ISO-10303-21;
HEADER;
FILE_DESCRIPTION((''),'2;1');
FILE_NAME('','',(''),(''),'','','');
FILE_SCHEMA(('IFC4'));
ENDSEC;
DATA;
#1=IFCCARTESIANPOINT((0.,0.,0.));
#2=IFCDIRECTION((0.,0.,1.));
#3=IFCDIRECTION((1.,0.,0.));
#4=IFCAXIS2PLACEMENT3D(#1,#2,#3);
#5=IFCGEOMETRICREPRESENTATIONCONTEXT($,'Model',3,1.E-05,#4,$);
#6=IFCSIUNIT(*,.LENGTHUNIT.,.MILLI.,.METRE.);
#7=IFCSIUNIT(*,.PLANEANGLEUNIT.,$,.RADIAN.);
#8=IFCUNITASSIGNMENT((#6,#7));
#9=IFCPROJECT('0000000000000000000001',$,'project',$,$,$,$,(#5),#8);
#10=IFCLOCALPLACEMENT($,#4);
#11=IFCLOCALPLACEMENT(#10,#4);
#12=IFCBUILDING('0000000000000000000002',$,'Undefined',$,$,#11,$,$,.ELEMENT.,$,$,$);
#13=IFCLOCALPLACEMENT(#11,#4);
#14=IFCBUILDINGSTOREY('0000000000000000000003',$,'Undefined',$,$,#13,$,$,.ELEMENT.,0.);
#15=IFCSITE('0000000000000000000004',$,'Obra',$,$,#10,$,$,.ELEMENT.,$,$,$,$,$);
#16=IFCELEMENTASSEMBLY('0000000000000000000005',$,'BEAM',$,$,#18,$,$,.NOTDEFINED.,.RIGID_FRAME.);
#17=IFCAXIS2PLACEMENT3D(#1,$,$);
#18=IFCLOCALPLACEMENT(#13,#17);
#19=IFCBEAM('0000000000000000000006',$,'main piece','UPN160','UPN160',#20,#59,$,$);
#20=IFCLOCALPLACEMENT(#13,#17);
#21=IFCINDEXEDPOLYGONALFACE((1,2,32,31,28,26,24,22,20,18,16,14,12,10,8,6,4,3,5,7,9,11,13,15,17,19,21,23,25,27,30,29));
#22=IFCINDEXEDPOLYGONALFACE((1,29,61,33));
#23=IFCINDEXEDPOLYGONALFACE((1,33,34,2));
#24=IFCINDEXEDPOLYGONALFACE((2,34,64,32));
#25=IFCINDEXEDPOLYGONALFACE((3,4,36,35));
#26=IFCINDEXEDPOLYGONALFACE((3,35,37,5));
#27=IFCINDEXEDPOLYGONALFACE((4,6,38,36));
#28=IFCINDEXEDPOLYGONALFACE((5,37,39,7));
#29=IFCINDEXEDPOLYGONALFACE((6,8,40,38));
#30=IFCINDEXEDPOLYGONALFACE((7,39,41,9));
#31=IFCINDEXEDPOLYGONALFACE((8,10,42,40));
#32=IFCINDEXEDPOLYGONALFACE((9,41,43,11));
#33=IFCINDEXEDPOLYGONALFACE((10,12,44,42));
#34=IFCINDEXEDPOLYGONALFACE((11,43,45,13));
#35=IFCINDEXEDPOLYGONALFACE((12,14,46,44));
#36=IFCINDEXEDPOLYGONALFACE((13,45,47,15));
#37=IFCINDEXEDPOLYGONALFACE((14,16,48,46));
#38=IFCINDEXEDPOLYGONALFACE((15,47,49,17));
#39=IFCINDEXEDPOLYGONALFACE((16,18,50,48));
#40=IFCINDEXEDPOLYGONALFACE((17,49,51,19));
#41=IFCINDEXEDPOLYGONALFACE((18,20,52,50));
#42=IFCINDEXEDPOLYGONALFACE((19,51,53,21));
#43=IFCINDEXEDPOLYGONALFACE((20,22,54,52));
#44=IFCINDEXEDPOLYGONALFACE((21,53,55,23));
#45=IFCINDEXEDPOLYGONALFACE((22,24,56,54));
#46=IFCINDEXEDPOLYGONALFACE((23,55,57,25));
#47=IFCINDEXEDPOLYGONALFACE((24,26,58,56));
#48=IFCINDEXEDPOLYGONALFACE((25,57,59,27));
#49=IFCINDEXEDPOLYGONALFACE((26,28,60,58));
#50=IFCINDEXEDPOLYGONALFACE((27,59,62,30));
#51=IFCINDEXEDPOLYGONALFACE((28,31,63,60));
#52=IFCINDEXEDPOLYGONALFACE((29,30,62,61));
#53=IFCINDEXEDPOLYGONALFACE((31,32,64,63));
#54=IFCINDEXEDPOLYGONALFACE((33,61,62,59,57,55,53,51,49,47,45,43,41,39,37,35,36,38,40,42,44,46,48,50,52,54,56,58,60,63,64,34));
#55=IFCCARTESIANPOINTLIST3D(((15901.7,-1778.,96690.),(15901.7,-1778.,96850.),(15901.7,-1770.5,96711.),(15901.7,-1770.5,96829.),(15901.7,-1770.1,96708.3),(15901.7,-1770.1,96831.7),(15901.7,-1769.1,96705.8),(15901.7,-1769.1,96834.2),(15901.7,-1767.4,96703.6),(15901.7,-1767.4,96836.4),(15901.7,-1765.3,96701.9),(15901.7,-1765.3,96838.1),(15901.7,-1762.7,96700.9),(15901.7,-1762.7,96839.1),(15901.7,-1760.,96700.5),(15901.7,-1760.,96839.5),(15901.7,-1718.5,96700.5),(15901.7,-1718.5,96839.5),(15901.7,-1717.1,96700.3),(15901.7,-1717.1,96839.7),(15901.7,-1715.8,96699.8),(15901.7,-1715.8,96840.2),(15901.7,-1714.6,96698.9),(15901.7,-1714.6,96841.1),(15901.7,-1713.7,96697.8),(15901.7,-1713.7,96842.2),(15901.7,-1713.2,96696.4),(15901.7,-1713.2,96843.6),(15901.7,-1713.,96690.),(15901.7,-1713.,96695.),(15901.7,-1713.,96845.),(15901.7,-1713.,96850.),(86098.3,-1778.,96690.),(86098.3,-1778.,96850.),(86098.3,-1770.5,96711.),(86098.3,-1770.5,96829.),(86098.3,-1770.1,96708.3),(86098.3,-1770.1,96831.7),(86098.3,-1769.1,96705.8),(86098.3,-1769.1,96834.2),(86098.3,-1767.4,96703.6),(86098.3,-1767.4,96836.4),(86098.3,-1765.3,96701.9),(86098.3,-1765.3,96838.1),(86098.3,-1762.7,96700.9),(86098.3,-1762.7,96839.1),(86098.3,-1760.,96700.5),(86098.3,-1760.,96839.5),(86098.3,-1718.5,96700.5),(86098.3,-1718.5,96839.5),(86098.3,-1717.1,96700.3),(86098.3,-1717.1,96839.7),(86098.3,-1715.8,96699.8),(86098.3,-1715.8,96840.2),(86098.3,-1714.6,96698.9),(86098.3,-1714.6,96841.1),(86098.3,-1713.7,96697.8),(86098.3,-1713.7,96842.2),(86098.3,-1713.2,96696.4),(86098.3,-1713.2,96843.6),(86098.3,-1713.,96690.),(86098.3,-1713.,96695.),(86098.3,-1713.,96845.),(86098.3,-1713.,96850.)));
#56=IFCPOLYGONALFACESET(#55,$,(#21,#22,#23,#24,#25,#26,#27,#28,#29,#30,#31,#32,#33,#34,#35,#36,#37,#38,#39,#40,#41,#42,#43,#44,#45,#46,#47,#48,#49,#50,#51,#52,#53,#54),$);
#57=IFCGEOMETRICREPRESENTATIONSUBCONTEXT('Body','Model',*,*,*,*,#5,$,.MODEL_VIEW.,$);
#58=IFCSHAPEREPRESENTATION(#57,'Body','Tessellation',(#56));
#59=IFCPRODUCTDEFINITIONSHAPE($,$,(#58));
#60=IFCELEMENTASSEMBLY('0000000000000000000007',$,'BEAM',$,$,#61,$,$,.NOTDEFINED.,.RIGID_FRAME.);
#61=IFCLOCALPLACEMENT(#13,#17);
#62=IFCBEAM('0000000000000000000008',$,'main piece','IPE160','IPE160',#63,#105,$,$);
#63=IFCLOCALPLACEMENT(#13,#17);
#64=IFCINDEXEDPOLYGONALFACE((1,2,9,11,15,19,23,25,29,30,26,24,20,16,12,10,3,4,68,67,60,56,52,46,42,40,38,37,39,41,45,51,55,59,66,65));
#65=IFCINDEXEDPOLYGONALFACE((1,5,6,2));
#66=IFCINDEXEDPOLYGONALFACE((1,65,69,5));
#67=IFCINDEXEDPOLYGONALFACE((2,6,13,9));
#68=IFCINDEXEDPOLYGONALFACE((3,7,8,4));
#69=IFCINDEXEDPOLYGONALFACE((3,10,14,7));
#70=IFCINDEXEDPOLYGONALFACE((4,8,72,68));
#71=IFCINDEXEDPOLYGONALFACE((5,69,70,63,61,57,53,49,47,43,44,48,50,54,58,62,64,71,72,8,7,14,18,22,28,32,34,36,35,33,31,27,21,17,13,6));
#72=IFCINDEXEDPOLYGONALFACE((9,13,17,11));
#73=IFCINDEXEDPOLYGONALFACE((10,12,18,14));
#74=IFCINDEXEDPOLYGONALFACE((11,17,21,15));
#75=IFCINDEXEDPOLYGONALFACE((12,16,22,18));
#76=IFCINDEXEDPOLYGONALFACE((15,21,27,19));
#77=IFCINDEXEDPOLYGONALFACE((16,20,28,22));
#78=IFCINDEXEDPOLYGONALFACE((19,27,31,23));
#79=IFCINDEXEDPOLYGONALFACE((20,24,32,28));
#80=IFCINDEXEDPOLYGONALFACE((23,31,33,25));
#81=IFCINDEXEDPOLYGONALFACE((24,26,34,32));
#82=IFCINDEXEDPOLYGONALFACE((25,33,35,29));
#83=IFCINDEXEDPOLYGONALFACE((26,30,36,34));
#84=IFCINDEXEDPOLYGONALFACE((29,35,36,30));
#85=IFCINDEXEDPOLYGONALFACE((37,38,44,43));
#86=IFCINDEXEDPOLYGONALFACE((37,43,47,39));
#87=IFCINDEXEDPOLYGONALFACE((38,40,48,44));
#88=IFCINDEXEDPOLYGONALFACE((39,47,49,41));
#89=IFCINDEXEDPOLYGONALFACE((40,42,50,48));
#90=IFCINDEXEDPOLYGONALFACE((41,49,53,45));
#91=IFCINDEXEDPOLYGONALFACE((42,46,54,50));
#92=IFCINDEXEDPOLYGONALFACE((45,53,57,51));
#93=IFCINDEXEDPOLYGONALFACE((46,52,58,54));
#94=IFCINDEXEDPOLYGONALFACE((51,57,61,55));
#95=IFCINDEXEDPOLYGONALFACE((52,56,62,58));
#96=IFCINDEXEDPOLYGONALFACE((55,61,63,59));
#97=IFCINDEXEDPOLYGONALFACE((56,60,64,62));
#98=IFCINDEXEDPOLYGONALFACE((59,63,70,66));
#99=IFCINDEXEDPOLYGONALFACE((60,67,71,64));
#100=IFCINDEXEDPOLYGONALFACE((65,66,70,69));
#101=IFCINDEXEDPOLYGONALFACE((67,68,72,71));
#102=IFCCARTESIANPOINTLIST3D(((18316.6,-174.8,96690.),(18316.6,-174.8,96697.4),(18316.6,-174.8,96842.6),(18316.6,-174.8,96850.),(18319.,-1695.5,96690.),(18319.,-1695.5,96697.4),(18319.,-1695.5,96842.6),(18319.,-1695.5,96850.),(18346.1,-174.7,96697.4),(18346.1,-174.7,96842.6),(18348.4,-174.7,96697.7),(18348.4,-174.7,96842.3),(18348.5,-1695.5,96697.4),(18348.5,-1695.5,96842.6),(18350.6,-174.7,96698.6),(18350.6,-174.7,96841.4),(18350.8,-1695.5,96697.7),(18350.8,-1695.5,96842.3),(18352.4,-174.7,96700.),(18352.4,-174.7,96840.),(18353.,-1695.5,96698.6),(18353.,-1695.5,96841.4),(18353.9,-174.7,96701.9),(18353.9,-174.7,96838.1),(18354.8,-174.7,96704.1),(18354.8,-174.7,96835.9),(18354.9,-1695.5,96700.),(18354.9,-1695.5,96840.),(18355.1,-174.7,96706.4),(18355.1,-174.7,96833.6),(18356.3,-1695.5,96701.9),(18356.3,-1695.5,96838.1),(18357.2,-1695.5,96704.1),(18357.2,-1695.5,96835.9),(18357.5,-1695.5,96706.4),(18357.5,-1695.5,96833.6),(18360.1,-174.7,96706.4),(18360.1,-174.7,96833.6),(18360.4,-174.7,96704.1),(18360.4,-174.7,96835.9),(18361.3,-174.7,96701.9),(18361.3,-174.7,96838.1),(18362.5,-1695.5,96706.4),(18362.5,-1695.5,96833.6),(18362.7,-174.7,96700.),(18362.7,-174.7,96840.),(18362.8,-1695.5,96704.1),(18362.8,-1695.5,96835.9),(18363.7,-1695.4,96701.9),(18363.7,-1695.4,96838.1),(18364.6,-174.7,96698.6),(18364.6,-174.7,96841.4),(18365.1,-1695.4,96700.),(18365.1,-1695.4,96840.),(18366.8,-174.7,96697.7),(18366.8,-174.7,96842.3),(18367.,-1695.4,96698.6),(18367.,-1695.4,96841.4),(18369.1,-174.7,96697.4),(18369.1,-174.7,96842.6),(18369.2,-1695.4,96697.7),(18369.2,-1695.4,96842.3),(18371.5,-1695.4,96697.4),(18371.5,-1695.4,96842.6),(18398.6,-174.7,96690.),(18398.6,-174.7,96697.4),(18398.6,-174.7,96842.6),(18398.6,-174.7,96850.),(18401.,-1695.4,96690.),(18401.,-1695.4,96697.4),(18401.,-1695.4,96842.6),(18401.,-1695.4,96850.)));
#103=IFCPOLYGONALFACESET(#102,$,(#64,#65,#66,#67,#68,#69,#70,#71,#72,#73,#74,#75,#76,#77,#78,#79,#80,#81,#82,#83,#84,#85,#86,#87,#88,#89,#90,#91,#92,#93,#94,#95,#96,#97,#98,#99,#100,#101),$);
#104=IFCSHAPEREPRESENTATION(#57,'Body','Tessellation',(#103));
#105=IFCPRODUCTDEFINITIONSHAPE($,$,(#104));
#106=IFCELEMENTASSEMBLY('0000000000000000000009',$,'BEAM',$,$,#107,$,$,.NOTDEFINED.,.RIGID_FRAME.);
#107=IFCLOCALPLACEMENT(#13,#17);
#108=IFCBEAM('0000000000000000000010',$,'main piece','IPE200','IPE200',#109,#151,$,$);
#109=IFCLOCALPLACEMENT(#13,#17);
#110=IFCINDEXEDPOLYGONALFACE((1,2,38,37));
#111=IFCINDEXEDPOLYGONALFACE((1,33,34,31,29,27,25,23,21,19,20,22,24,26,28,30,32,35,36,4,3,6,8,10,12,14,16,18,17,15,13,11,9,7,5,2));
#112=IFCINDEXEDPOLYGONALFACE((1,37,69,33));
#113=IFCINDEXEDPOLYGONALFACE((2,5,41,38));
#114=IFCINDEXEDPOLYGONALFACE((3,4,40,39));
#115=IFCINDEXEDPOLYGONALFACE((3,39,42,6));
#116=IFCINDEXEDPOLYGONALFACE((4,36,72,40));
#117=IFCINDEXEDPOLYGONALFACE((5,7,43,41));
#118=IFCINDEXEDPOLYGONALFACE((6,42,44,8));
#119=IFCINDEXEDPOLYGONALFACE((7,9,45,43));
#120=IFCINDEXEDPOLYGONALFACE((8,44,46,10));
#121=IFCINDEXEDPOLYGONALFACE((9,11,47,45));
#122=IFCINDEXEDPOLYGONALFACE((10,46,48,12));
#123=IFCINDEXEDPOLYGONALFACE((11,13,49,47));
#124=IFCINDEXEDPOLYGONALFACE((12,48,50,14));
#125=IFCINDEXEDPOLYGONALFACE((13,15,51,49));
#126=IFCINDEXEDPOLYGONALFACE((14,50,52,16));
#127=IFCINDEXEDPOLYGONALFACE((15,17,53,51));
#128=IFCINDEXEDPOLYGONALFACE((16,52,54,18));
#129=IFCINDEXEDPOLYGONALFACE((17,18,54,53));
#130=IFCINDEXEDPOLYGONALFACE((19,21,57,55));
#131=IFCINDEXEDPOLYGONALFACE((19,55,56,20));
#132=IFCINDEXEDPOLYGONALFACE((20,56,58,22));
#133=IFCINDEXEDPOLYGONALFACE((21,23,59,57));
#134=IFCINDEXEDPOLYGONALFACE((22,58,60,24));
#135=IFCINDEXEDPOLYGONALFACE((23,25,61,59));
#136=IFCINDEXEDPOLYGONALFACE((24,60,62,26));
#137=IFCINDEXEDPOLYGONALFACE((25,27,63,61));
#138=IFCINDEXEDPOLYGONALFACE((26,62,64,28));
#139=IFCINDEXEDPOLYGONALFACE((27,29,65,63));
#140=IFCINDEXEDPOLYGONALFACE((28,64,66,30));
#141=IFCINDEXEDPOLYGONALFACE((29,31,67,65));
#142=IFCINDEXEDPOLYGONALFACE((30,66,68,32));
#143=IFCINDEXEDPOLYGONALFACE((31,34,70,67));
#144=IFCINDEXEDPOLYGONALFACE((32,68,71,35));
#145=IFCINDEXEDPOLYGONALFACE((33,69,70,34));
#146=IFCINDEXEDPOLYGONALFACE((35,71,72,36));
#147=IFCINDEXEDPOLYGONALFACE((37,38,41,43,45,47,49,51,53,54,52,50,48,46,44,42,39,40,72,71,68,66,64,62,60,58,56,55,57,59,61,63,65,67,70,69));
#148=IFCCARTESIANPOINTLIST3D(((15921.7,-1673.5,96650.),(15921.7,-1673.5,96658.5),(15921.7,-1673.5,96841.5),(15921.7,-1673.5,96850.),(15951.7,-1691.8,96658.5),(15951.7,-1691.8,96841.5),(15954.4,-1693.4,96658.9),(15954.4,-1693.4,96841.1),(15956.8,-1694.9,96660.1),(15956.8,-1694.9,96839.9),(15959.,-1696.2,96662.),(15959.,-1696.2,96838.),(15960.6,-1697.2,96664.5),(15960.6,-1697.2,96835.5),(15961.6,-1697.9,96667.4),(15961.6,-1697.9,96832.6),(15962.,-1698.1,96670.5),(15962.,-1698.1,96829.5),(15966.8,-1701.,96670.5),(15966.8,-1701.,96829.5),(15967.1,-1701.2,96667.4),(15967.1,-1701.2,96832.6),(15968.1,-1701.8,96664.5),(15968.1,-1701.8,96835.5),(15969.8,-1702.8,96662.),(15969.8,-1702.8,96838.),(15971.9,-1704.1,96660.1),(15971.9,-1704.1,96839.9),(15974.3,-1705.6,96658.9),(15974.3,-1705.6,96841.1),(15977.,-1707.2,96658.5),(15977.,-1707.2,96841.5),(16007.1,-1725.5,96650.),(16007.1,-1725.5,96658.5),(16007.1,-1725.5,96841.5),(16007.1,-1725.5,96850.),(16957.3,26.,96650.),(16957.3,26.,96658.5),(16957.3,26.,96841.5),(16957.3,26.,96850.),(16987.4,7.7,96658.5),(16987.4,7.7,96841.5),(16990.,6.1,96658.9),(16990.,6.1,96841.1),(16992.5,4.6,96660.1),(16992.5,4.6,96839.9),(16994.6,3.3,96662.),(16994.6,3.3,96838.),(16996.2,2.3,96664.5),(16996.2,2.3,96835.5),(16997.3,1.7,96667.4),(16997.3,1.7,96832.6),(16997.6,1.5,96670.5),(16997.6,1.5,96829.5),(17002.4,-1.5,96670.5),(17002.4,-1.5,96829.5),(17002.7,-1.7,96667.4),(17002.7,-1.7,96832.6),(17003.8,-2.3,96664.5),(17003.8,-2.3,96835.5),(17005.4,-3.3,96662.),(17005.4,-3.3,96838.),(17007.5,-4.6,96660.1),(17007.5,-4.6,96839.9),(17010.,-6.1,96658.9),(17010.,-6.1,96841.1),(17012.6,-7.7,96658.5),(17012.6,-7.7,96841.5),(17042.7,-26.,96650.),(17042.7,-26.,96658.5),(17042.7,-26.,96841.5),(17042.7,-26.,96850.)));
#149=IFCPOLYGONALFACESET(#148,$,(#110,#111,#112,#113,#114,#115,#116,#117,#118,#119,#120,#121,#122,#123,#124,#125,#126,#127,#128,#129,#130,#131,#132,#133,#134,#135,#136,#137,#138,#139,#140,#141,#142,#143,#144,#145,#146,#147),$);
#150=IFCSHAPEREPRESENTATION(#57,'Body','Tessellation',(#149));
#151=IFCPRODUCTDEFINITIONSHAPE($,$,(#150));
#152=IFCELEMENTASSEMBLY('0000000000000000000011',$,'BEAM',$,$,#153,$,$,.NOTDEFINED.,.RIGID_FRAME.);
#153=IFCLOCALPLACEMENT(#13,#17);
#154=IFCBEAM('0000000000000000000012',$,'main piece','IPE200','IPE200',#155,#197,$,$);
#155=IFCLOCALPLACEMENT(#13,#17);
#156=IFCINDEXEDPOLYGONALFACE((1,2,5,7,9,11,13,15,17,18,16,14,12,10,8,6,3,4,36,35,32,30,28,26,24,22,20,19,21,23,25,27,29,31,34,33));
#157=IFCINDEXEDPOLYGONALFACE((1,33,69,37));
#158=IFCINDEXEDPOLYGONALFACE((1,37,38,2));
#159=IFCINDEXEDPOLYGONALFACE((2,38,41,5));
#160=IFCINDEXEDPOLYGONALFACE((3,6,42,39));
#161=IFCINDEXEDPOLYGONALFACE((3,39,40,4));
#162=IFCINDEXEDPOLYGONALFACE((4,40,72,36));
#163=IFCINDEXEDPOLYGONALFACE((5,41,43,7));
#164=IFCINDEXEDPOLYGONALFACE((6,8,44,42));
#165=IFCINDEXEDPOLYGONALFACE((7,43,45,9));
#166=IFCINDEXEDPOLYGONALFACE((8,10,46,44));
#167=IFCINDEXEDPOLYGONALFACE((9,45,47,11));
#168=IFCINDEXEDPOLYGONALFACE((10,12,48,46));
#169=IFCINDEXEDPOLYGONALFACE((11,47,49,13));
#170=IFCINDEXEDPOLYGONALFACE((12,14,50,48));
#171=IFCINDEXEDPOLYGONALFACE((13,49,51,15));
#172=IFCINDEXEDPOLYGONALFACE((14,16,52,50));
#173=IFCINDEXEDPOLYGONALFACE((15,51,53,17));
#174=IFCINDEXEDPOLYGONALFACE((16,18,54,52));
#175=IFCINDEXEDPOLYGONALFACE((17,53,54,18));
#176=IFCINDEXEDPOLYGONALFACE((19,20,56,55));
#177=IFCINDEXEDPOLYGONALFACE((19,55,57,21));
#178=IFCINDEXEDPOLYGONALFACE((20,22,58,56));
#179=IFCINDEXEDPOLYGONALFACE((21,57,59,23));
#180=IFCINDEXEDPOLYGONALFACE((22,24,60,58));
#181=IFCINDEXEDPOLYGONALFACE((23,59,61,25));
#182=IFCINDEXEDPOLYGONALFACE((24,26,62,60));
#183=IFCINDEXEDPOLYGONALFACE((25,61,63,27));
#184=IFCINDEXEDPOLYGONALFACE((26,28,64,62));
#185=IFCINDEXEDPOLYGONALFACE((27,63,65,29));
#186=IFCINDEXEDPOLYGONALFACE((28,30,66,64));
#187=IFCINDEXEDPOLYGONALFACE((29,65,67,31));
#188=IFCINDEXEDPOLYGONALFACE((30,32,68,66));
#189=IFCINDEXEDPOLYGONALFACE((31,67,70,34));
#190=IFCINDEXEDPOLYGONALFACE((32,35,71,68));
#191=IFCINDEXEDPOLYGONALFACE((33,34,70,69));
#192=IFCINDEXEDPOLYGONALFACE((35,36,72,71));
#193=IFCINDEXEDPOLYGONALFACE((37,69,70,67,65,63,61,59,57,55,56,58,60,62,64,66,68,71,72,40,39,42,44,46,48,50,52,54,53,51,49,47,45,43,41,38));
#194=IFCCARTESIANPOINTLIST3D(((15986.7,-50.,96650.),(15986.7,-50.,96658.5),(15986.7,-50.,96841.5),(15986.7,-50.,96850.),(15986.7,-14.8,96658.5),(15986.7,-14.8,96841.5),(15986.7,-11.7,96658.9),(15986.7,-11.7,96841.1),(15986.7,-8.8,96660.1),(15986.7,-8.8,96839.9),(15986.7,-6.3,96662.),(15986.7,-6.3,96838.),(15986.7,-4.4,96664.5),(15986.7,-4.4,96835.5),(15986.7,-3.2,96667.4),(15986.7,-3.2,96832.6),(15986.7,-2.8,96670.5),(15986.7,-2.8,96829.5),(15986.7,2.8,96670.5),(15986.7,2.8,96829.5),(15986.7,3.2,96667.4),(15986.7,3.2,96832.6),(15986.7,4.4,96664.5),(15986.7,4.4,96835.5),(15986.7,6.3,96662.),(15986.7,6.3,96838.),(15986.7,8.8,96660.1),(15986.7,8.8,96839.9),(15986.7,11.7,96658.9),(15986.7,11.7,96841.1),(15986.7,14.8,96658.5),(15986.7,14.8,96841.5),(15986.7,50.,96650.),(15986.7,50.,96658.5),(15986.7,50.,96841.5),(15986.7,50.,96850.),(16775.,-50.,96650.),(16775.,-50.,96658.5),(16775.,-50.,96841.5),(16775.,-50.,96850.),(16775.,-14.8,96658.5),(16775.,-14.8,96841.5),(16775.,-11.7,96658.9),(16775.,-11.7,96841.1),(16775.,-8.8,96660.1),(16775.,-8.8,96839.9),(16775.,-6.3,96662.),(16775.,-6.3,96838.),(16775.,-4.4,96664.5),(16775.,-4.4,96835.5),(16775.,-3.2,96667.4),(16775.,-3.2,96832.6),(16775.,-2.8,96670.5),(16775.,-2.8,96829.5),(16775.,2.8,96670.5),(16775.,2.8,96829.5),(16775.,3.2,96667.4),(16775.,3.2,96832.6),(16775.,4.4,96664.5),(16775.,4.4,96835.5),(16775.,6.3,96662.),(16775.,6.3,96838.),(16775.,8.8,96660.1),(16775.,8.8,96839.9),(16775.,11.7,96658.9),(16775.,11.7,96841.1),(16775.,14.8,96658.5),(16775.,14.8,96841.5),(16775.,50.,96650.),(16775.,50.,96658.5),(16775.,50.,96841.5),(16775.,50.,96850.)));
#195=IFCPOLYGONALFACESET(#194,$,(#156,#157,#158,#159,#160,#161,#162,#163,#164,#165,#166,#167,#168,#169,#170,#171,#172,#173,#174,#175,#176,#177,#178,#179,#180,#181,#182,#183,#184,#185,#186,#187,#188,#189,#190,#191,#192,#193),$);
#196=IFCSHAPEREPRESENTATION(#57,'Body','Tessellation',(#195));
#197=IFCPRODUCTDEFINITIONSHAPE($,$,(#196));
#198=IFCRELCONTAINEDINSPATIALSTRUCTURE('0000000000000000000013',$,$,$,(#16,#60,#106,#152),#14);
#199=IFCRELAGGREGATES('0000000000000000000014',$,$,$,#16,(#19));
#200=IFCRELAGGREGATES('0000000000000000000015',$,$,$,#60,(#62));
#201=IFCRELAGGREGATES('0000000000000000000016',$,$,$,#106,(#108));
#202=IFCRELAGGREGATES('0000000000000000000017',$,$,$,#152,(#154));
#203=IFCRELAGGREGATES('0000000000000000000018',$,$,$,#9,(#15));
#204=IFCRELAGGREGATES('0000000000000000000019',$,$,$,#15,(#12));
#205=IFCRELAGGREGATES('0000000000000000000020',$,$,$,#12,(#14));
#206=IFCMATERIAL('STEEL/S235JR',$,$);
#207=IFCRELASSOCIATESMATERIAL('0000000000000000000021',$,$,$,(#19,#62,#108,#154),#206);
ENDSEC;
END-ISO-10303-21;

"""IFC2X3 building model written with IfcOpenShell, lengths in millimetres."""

from ifc_helpers import new_model, si_unit, frame, origin_with_axes, origin_2d_with_axis, place, context, subcontext, project, spatial, i_section, u_section, extrude, material, element, aggregate, save


model = new_model("IFC2X3")

# Units and contexts
model_context = context("Model", 3, precision=1e-05, world=origin_with_axes())
body_context = subcontext(model_context, "Body", "Model", "MODEL_VIEW")
ifc_project = project(units=[si_unit("LENGTHUNIT", "METRE", prefix="MILLI"), si_unit("PLANEANGLEUNIT", "RADIAN")], contexts=[model_context])

# Site, building, storey
site_placement = place(None, origin_with_axes())
site = spatial("IfcSite", under=ifc_project, at=site_placement, Name="Obra", CompositionType="ELEMENT")
building_placement = place(site_placement, origin_with_axes())
building = spatial("IfcBuilding", under=site, at=building_placement, Name="Undefined", CompositionType="ELEMENT")
storey_placement = place(building_placement, origin_with_axes())
storey = spatial("IfcBuildingStorey", under=building, at=storey_placement, Name="Undefined", CompositionType="ELEMENT", Elevation=0.0)

# Element assemblies, beams
assembly_1_placement = place(storey_placement, origin_with_axes())
assembly_1 = element("IfcElementAssembly", 1, at=assembly_1_placement, inside=storey, Name="BEAM", AssemblyPlace="NOTDEFINED", PredefinedType="RIGID_FRAME")
ifc_material = material(Name="STEEL/S235JR")
beam_1_placement = place(assembly_1_placement, frame((15901.7, -1745.5, 96770.0), z_axis=(0.0, 0.0, -1.0), x_axis=(1.0, 0.0, 0.0)))
beam_1 = element("IfcBeam", 2, at=beam_1_placement, material=ifc_material, Name="main piece", Description="UPN160", ObjectType="UPN160", context=body_context, shape_type="SweptSolid", body=[
    extrude(u_section(Depth=160.0, FlangeWidth=65.0, WebThickness=7.5, FlangeThickness=10.5, FilletRadius=10.5, EdgeRadius=5.5, at=origin_2d_with_axis()), frame((70196.6, 0.0, 0.0), z_axis=(-1.0, 0.0, 0.0), x_axis=(0.0, -1.0, 0.0)), (0.0, 0.0, 1.0), 70196.6),
])
aggregate(assembly_1, [beam_1])
assembly_2_placement = place(storey_placement, origin_with_axes())
assembly_2 = element("IfcElementAssembly", 3, at=assembly_2_placement, inside=storey, Name="BEAM", AssemblyPlace="NOTDEFINED", PredefinedType="RIGID_FRAME")
beam_2_placement = place(assembly_2_placement, frame((18360.0, -1695.5, 96770.0), z_axis=(0.0, 0.0, 1.0), x_axis=(-0.001588, 0.999999, 0.0)))
beam_2 = element("IfcBeam", 4, at=beam_2_placement, material=ifc_material, Name="main piece", Description="IPE160", ObjectType="IPE160", context=body_context, shape_type="SweptSolid", body=[
    extrude(i_section(OverallWidth=82.0, OverallDepth=160.0, WebThickness=5.0, FlangeThickness=7.4, FilletRadius=9.0, at=origin_2d_with_axis()), frame((1520.7, 0.0, 0.0), z_axis=(-1.0, 0.0, 0.0), x_axis=(0.0, -1.0, 0.0)), (0.0, 0.0, 1.0), 1520.7),
])
aggregate(assembly_2, [beam_2])
assembly_3_placement = place(storey_placement, origin_with_axes())
assembly_3 = element("IfcElementAssembly", 5, at=assembly_3_placement, inside=storey, Name="BEAM", AssemblyPlace="NOTDEFINED", PredefinedType="RIGID_FRAME")
beam_3_placement = place(assembly_3_placement, frame((17000.0, 0.0, 96750.0), z_axis=(0.0, 0.0, 1.0), x_axis=(-0.520368, -0.853942, 0.0)))
beam_3 = element("IfcBeam", 6, at=beam_3_placement, material=ifc_material, Name="main piece", Description="IPE200", ObjectType="IPE200", context=body_context, shape_type="SweptSolid", body=[
    extrude(i_section(OverallWidth=100.0, OverallDepth=200.0, WebThickness=5.6, FlangeThickness=8.5, FilletRadius=12.0, at=origin_2d_with_axis()), frame((1990.2, 0.0, 0.0), z_axis=(-1.0, 0.0, 0.0), x_axis=(0.0, -1.0, 0.0)), (0.0, 0.0, 1.0), 1990.2),
])
aggregate(assembly_3, [beam_3])
assembly_4_placement = place(storey_placement, origin_with_axes())
assembly_4 = element("IfcElementAssembly", 7, at=assembly_4_placement, inside=storey, Name="BEAM", AssemblyPlace="NOTDEFINED", PredefinedType="RIGID_FRAME")
beam_4_placement = place(assembly_4_placement, frame((16775.0, 0.0, 96750.0), z_axis=(0.0, 0.0, 1.0), x_axis=(-1.0, 0.0, 0.0)))
beam_4 = element("IfcBeam", 8, at=beam_4_placement, material=ifc_material, Name="main piece", Description="IPE200", ObjectType="IPE200", context=body_context, shape_type="SweptSolid", body=[
    extrude(i_section(OverallWidth=100.0, OverallDepth=200.0, WebThickness=5.6, FlangeThickness=8.5, FilletRadius=12.0, at=origin_2d_with_axis()), frame((788.3, 0.0, 0.0), z_axis=(-1.0, 0.0, 0.0), x_axis=(0.0, -1.0, 0.0)), (0.0, 0.0, 1.0), 788.3),
])
aggregate(assembly_4, [beam_4])

save(model, "model.ifc")
